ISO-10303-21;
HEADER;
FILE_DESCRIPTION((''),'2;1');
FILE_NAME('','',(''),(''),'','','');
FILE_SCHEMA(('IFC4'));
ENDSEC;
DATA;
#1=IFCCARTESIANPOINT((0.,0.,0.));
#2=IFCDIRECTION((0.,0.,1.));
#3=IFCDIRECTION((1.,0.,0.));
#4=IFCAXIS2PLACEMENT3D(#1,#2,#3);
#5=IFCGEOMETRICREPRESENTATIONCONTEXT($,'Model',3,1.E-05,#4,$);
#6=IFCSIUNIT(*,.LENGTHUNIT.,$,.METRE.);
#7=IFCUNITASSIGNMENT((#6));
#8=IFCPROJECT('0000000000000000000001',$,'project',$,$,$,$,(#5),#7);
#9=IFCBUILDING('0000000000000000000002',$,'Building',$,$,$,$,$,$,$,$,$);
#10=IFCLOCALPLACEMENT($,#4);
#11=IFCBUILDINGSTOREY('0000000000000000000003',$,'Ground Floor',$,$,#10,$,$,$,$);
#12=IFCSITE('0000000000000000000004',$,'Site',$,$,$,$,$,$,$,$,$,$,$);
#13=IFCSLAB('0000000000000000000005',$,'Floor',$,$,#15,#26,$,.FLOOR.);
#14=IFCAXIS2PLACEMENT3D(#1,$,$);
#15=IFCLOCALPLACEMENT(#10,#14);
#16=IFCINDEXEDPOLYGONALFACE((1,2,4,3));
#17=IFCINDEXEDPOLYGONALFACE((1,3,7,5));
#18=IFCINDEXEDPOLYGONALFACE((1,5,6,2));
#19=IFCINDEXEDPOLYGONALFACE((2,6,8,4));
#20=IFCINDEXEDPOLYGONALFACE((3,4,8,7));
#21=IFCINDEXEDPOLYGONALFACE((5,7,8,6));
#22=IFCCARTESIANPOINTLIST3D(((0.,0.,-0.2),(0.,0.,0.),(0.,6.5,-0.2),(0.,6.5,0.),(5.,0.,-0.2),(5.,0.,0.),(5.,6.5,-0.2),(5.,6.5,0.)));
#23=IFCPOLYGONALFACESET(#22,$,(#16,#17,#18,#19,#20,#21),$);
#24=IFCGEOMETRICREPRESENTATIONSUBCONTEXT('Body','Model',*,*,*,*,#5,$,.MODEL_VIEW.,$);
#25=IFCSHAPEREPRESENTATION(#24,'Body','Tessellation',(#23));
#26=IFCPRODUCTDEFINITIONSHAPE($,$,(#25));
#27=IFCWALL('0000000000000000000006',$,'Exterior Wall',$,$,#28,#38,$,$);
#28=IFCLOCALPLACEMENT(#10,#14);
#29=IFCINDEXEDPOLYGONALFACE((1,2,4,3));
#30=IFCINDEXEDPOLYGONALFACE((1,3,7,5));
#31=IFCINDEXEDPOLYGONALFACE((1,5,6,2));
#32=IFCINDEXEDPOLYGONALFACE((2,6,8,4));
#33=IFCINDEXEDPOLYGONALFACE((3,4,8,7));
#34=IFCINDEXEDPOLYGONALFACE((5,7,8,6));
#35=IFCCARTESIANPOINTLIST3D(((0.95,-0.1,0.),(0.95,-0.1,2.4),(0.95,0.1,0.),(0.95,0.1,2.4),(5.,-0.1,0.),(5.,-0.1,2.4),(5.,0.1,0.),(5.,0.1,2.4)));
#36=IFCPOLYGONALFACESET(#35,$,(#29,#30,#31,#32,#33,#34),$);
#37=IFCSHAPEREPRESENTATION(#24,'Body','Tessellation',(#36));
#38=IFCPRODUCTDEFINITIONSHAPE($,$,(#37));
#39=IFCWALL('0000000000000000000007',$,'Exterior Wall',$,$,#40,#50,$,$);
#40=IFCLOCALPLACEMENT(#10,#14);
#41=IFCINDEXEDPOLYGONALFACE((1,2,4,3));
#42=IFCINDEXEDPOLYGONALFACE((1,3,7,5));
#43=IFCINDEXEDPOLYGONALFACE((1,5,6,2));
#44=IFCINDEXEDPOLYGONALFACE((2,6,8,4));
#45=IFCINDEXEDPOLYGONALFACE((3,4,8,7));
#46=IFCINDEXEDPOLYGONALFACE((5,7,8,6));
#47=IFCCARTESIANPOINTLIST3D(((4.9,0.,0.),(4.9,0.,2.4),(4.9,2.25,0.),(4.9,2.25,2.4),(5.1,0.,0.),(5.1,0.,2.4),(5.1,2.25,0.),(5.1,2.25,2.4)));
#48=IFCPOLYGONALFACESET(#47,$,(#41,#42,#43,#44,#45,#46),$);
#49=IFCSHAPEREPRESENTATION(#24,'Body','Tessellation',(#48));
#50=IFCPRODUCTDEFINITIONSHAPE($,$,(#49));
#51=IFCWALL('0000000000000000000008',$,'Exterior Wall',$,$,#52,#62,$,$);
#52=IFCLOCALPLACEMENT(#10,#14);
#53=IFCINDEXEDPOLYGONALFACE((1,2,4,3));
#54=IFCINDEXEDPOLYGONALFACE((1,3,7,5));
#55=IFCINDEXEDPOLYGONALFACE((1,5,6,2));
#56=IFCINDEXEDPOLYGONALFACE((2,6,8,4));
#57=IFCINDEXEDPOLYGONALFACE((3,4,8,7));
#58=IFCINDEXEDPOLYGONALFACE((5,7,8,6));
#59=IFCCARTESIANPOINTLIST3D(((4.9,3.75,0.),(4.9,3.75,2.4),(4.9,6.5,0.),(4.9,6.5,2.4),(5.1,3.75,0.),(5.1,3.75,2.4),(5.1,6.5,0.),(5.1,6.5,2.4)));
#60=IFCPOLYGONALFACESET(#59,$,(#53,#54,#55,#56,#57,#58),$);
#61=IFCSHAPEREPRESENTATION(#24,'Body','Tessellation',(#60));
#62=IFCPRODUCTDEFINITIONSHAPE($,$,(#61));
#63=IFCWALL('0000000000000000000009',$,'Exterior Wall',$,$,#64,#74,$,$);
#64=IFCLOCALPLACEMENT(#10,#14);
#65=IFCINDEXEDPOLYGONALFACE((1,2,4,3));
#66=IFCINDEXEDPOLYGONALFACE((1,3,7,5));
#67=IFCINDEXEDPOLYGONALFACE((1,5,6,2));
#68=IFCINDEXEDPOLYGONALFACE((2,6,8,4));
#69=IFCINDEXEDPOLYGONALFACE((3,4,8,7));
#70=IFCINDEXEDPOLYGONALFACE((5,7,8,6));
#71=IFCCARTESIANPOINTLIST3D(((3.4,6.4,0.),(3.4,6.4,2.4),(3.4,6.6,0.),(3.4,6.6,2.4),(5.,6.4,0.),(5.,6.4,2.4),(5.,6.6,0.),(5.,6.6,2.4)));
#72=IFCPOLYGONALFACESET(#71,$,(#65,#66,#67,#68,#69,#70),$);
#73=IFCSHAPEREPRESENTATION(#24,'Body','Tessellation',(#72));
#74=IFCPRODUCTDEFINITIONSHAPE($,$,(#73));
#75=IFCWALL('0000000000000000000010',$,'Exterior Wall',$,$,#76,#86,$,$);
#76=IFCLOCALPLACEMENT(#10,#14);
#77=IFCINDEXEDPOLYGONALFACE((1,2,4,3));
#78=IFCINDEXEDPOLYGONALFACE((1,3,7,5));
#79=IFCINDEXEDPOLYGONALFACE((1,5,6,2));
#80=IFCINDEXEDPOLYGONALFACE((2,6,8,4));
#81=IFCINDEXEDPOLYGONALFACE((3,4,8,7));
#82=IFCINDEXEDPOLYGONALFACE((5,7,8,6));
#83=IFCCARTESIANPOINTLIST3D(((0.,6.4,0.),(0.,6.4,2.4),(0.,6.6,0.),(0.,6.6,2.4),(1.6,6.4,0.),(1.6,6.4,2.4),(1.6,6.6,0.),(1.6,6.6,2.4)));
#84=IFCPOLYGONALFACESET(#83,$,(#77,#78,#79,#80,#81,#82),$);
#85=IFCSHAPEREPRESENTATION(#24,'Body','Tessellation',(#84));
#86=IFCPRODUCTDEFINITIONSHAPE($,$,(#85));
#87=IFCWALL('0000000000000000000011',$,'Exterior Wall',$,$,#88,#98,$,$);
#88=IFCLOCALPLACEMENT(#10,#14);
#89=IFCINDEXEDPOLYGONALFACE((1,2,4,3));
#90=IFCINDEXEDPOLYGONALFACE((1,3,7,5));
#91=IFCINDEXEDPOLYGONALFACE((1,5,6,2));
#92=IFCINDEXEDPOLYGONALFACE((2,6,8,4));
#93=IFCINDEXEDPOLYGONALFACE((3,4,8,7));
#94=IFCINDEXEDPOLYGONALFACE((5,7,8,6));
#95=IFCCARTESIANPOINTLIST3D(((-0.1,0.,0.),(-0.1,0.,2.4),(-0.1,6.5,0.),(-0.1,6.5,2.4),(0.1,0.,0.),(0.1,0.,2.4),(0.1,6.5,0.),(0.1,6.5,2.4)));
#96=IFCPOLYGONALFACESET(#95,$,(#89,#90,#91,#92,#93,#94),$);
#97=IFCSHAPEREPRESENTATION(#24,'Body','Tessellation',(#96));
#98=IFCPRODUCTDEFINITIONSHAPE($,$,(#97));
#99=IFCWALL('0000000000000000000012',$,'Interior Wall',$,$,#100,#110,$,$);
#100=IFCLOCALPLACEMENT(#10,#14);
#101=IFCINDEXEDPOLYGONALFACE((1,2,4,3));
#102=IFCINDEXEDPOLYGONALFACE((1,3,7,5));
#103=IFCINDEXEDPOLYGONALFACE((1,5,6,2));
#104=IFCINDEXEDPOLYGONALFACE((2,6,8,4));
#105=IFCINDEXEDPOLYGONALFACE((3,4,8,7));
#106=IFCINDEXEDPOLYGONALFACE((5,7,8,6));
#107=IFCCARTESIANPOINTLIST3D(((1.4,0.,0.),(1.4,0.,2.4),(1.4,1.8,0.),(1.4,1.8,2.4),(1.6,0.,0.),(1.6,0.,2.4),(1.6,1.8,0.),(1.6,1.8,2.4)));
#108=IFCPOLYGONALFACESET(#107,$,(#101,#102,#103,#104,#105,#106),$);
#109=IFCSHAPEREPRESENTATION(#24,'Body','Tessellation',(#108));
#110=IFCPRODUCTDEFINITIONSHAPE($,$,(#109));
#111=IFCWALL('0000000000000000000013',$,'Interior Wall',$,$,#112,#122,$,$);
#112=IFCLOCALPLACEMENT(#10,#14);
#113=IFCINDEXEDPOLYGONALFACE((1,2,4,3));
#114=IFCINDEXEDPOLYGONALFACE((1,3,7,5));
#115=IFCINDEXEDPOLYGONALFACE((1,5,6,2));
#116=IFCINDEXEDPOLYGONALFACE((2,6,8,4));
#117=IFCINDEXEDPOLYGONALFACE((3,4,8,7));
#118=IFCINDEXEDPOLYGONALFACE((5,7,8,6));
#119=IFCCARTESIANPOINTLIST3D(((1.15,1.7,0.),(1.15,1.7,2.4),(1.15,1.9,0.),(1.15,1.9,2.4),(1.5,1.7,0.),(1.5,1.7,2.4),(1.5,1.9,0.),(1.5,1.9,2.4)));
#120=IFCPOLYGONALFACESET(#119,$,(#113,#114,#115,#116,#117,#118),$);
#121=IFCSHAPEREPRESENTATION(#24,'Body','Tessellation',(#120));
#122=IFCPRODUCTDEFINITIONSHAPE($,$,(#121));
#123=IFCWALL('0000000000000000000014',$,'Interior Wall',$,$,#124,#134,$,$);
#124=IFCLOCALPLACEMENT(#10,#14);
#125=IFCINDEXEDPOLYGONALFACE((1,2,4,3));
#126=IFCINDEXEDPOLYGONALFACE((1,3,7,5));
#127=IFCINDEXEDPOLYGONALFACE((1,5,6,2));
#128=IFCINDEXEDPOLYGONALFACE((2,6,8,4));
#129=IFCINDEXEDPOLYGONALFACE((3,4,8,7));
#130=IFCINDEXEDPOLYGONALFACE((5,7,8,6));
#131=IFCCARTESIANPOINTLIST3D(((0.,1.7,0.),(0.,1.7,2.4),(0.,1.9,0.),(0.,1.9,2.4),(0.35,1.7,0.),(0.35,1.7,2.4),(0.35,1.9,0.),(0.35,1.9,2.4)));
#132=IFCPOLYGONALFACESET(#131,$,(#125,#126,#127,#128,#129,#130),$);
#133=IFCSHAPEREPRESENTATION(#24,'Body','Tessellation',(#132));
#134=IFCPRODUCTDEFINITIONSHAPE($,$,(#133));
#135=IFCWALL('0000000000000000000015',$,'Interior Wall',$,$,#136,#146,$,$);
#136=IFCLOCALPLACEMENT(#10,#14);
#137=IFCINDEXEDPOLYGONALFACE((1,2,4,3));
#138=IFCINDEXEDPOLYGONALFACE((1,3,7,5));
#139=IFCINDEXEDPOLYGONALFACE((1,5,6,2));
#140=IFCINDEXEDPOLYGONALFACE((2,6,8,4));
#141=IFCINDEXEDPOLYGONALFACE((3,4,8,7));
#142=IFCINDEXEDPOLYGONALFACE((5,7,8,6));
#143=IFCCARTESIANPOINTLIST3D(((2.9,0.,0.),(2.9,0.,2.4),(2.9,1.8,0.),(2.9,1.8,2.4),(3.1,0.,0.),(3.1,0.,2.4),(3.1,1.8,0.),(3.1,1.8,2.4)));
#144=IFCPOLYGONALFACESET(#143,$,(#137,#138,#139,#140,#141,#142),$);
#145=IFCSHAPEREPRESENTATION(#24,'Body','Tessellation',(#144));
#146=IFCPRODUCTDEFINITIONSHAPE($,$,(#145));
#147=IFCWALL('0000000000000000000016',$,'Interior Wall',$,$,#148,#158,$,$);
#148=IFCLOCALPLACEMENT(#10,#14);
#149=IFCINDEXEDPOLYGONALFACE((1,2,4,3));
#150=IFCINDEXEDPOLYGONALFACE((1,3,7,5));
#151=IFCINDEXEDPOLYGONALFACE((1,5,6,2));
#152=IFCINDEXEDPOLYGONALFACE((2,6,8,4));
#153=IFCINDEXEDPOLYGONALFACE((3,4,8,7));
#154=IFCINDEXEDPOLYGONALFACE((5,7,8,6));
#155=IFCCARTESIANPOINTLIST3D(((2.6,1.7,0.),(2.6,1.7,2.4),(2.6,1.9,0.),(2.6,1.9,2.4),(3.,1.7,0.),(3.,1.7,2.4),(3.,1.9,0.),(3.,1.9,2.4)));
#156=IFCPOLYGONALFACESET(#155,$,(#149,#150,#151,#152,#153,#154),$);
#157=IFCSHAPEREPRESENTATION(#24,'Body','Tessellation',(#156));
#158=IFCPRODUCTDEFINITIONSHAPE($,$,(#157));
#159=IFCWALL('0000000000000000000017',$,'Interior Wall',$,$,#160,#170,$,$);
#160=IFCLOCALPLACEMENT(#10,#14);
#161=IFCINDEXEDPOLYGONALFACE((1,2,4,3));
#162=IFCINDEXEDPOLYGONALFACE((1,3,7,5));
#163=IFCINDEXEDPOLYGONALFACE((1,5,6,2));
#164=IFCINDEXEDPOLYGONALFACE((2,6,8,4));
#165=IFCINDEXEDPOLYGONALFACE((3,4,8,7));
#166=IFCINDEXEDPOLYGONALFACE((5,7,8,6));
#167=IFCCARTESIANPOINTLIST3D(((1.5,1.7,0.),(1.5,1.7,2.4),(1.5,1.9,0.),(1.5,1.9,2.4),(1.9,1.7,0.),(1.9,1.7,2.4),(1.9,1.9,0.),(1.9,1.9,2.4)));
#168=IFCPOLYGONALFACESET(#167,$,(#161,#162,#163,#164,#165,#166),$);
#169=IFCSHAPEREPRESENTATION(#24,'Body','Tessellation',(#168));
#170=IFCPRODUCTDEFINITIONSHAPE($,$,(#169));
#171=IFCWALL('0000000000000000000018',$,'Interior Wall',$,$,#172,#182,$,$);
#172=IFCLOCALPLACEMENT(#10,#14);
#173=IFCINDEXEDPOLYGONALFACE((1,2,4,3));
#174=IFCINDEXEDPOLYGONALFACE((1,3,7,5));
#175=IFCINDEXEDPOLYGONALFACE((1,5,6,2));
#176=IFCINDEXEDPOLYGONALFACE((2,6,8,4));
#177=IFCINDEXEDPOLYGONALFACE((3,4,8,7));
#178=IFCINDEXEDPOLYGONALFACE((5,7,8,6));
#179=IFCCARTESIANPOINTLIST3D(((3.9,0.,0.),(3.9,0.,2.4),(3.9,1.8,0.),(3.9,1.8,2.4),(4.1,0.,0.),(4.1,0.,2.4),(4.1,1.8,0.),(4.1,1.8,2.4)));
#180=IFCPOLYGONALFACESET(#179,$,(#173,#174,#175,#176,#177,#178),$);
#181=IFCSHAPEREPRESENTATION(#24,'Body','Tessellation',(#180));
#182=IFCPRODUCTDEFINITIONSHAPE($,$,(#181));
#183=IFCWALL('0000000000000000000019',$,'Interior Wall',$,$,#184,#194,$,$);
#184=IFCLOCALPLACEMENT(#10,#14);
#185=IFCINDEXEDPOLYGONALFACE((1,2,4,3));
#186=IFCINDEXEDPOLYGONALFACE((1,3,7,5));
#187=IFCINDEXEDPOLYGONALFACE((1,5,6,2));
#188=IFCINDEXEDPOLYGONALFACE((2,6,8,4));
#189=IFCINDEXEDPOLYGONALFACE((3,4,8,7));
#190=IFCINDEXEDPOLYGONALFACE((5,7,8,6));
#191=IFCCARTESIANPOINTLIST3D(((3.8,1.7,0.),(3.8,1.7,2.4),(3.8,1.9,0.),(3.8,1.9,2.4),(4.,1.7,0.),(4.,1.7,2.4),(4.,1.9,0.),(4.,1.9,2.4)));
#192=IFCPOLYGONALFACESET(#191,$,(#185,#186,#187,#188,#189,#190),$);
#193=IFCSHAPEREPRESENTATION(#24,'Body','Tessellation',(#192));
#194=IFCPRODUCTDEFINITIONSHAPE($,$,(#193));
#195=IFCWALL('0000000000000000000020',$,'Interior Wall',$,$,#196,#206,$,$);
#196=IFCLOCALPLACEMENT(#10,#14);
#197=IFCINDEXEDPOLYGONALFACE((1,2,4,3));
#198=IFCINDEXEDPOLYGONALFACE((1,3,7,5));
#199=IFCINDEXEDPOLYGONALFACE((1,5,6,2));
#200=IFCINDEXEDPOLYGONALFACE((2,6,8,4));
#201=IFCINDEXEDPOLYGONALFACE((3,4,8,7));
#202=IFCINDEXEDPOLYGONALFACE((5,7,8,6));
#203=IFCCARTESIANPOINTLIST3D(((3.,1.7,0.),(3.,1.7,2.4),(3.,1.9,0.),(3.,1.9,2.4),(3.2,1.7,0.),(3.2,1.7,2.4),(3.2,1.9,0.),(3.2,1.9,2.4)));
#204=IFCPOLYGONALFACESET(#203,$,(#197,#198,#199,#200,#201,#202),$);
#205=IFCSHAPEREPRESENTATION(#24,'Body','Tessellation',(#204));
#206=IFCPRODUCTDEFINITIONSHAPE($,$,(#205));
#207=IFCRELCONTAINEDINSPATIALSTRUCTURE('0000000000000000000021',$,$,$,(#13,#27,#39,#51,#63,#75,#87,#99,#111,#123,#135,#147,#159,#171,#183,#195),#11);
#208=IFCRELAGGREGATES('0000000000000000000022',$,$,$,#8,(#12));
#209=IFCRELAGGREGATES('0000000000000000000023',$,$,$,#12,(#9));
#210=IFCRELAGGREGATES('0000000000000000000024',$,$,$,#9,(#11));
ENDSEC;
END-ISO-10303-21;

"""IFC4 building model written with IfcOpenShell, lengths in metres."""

from ifc_helpers import new_model, si_unit, frame, origin_with_axes, place, context, subcontext, project, spatial, indexed_curve, outline, extrude, element, save


model = new_model("IFC4")

# Units and contexts
model_context = context("Model", 3, precision=1e-05, world=origin_with_axes())
body_context = subcontext(model_context, "Body", "Model", "MODEL_VIEW")
ifc_project = project(units=[si_unit("LENGTHUNIT", "METRE")], contexts=[model_context])

# Site, building, storey
site = spatial("IfcSite", under=ifc_project, Name="Site")
building = spatial("IfcBuilding", under=site, Name="Building")
storey_placement = place(None, origin_with_axes())
storey = spatial("IfcBuildingStorey", under=building, at=storey_placement, Name="Ground Floor")

# Slab
slab_placement = place(storey_placement, frame((0.0, 0.0, -0.2), z_axis=(0.0, 0.0, 1.0), x_axis=(1.0, 0.0, 0.0)))
element("IfcSlab", 1, at=slab_placement, inside=storey, Name="Floor", PredefinedType="FLOOR", context=body_context, shape_type="SweptSolid", body=[
    extrude(outline(indexed_curve([(0.0, 0.0), (5.0, 0.0), (5.0, 6.5), (0.0, 6.5)])), None, (0.0, 0.0, 1.0), 0.2),
])

# Walls
wall_1_placement = place(storey_placement, frame((0.95, 0.0, 0.0), z_axis=(0.0, 0.0, 1.0), x_axis=(1.0, 0.0, 0.0)))
element("IfcWall", 2, at=wall_1_placement, inside=storey, Name="Exterior Wall", context=body_context, shape_type="SweptSolid", body=[
    extrude(outline(indexed_curve([(0.0, 0.0), (0.0, 0.2), (4.05, 0.2), (4.05, 0.0), (0.0, 0.0)], self_intersect=False)), frame((0.0, -0.1, 0.0), z_axis=(0.0, 0.0, 1.0), x_axis=(1.0, 0.0, 0.0)), (0.0, 0.0, 1.0), 2.4),
])
wall_2_placement = place(storey_placement, frame((5.0, 0.0, 0.0), z_axis=(0.0, 0.0, 1.0), x_axis=(0.0, 1.0, 0.0)))
element("IfcWall", 3, at=wall_2_placement, inside=storey, Name="Exterior Wall", context=body_context, shape_type="SweptSolid", body=[
    extrude(outline(indexed_curve([(0.0, 0.0), (0.0, 0.2), (2.25, 0.2), (2.25, 0.0), (0.0, 0.0)], self_intersect=False)), frame((0.0, -0.1, 0.0), z_axis=(0.0, 0.0, 1.0), x_axis=(1.0, 0.0, 0.0)), (0.0, 0.0, 1.0), 2.4),
])
wall_3_placement = place(storey_placement, frame((5.0, 3.75, 0.0), z_axis=(0.0, 0.0, 1.0), x_axis=(0.0, 1.0, 0.0)))
element("IfcWall", 4, at=wall_3_placement, inside=storey, Name="Exterior Wall", context=body_context, shape_type="SweptSolid", body=[
    extrude(outline(indexed_curve([(0.0, 0.0), (0.0, 0.2), (2.75, 0.2), (2.75, 0.0), (0.0, 0.0)], self_intersect=False)), frame((0.0, -0.1, 0.0), z_axis=(0.0, 0.0, 1.0), x_axis=(1.0, 0.0, 0.0)), (0.0, 0.0, 1.0), 2.4),
])
for number, where, z_axis, x_axis, name in (
    (5, (5.0, 6.5, 0.0), (0.0, 0.0, 1.0), (-1.0, 0.0, 0.0), "Exterior Wall"),
    (6, (1.6, 6.5, 0.0), (0.0, 0.0, 1.0), (-1.0, 0.0, 0.0), "Exterior Wall"),
):
    element("IfcWall", number, at=place(storey_placement, frame(where, z_axis=z_axis, x_axis=x_axis)), inside=storey, Name=name, context=body_context, shape_type="SweptSolid", body=[
        extrude(outline(indexed_curve([(0.0, 0.0), (0.0, 0.2), (1.6, 0.2), (1.6, 0.0), (0.0, 0.0)], self_intersect=False)), frame((0.0, -0.1, 0.0), z_axis=(0.0, 0.0, 1.0), x_axis=(1.0, 0.0, 0.0)), (0.0, 0.0, 1.0), 2.4),
    ])
wall_4_placement = place(storey_placement, frame((0.0, 6.5, 0.0), z_axis=(0.0, 0.0, 1.0), x_axis=(0.0, -1.0, 0.0)))
element("IfcWall", 7, at=wall_4_placement, inside=storey, Name="Exterior Wall", context=body_context, shape_type="SweptSolid", body=[
    extrude(outline(indexed_curve([(0.0, 0.0), (0.0, 0.2), (6.5, 0.2), (6.5, 0.0), (0.0, 0.0)], self_intersect=False)), frame((0.0, -0.1, 0.0), z_axis=(0.0, 0.0, 1.0), x_axis=(1.0, 0.0, 0.0)), (0.0, 0.0, 1.0), 2.4),
])
wall_5_placement = place(storey_placement, frame((1.5, 0.0, 0.0), z_axis=(0.0, 0.0, 1.0), x_axis=(0.0, 1.0, 0.0)))
element("IfcWall", 8, at=wall_5_placement, inside=storey, Name="Interior Wall", context=body_context, shape_type="SweptSolid", body=[
    extrude(outline(indexed_curve([(0.0, 0.0), (0.0, 0.2), (1.8, 0.2), (1.8, 0.0), (0.0, 0.0)], self_intersect=False)), frame((0.0, -0.1, 0.0), z_axis=(0.0, 0.0, 1.0), x_axis=(1.0, 0.0, 0.0)), (0.0, 0.0, 1.0), 2.4),
])
for number, where, z_axis, x_axis, name in (
    (9, (1.5, 1.8, 0.0), (0.0, 0.0, 1.0), (-1.0, 0.0, 0.0), "Interior Wall"),
    (10, (0.35, 1.8, 0.0), (0.0, 0.0, 1.0), (-1.0, 0.0, 0.0), "Interior Wall"),
):
    element("IfcWall", number, at=place(storey_placement, frame(where, z_axis=z_axis, x_axis=x_axis)), inside=storey, Name=name, context=body_context, shape_type="SweptSolid", body=[
        extrude(outline(indexed_curve([(0.0, 0.0), (0.0, 0.2), (0.35, 0.2), (0.35, 0.0), (0.0, 0.0)], self_intersect=False)), frame((0.0, -0.1, 0.0), z_axis=(0.0, 0.0, 1.0), x_axis=(1.0, 0.0, 0.0)), (0.0, 0.0, 1.0), 2.4),
    ])
wall_6_placement = place(storey_placement, frame((3.0, 0.0, 0.0), z_axis=(0.0, 0.0, 1.0), x_axis=(0.0, 1.0, 0.0)))
element("IfcWall", 11, at=wall_6_placement, inside=storey, Name="Interior Wall", context=body_context, shape_type="SweptSolid", body=[
    extrude(outline(indexed_curve([(0.0, 0.0), (0.0, 0.2), (1.8, 0.2), (1.8, 0.0), (0.0, 0.0)], self_intersect=False)), frame((0.0, -0.1, 0.0), z_axis=(0.0, 0.0, 1.0), x_axis=(1.0, 0.0, 0.0)), (0.0, 0.0, 1.0), 2.4),
])
for number, where, z_axis, x_axis, name in (
    (12, (3.0, 1.8, 0.0), (0.0, 0.0, 1.0), (-1.0, 0.0, 0.0), "Interior Wall"),
    (13, (1.9, 1.8, 0.0), (0.0, 0.0, 1.0), (-1.0, 0.0, 0.0), "Interior Wall"),
):
    element("IfcWall", number, at=place(storey_placement, frame(where, z_axis=z_axis, x_axis=x_axis)), inside=storey, Name=name, context=body_context, shape_type="SweptSolid", body=[
        extrude(outline(indexed_curve([(0.0, 0.0), (0.0, 0.2), (0.4, 0.2), (0.4, 0.0), (0.0, 0.0)], self_intersect=False)), frame((0.0, -0.1, 0.0), z_axis=(0.0, 0.0, 1.0), x_axis=(1.0, 0.0, 0.0)), (0.0, 0.0, 1.0), 2.4),
    ])
wall_7_placement = place(storey_placement, frame((4.0, 0.0, 0.0), z_axis=(0.0, 0.0, 1.0), x_axis=(0.0, 1.0, 0.0)))
element("IfcWall", 14, at=wall_7_placement, inside=storey, Name="Interior Wall", context=body_context, shape_type="SweptSolid", body=[
    extrude(outline(indexed_curve([(0.0, 0.0), (0.0, 0.2), (1.8, 0.2), (1.8, 0.0), (0.0, 0.0)], self_intersect=False)), frame((0.0, -0.1, 0.0), z_axis=(0.0, 0.0, 1.0), x_axis=(1.0, 0.0, 0.0)), (0.0, 0.0, 1.0), 2.4),
])
for number, where, z_axis, x_axis, name in (
    (15, (4.0, 1.8, 0.0), (0.0, 0.0, 1.0), (-1.0, 0.0, 0.0), "Interior Wall"),
    (16, (3.2, 1.8, 0.0), (0.0, 0.0, 1.0), (-1.0, 0.0, 0.0), "Interior Wall"),
):
    element("IfcWall", number, at=place(storey_placement, frame(where, z_axis=z_axis, x_axis=x_axis)), inside=storey, Name=name, context=body_context, shape_type="SweptSolid", body=[
        extrude(outline(indexed_curve([(0.0, 0.0), (0.0, 0.2), (0.2, 0.2), (0.2, 0.0), (0.0, 0.0)], self_intersect=False)), frame((0.0, -0.1, 0.0), z_axis=(0.0, 0.0, 1.0), x_axis=(1.0, 0.0, 0.0)), (0.0, 0.0, 1.0), 2.4),
    ])

save(model, "model.ifc")
